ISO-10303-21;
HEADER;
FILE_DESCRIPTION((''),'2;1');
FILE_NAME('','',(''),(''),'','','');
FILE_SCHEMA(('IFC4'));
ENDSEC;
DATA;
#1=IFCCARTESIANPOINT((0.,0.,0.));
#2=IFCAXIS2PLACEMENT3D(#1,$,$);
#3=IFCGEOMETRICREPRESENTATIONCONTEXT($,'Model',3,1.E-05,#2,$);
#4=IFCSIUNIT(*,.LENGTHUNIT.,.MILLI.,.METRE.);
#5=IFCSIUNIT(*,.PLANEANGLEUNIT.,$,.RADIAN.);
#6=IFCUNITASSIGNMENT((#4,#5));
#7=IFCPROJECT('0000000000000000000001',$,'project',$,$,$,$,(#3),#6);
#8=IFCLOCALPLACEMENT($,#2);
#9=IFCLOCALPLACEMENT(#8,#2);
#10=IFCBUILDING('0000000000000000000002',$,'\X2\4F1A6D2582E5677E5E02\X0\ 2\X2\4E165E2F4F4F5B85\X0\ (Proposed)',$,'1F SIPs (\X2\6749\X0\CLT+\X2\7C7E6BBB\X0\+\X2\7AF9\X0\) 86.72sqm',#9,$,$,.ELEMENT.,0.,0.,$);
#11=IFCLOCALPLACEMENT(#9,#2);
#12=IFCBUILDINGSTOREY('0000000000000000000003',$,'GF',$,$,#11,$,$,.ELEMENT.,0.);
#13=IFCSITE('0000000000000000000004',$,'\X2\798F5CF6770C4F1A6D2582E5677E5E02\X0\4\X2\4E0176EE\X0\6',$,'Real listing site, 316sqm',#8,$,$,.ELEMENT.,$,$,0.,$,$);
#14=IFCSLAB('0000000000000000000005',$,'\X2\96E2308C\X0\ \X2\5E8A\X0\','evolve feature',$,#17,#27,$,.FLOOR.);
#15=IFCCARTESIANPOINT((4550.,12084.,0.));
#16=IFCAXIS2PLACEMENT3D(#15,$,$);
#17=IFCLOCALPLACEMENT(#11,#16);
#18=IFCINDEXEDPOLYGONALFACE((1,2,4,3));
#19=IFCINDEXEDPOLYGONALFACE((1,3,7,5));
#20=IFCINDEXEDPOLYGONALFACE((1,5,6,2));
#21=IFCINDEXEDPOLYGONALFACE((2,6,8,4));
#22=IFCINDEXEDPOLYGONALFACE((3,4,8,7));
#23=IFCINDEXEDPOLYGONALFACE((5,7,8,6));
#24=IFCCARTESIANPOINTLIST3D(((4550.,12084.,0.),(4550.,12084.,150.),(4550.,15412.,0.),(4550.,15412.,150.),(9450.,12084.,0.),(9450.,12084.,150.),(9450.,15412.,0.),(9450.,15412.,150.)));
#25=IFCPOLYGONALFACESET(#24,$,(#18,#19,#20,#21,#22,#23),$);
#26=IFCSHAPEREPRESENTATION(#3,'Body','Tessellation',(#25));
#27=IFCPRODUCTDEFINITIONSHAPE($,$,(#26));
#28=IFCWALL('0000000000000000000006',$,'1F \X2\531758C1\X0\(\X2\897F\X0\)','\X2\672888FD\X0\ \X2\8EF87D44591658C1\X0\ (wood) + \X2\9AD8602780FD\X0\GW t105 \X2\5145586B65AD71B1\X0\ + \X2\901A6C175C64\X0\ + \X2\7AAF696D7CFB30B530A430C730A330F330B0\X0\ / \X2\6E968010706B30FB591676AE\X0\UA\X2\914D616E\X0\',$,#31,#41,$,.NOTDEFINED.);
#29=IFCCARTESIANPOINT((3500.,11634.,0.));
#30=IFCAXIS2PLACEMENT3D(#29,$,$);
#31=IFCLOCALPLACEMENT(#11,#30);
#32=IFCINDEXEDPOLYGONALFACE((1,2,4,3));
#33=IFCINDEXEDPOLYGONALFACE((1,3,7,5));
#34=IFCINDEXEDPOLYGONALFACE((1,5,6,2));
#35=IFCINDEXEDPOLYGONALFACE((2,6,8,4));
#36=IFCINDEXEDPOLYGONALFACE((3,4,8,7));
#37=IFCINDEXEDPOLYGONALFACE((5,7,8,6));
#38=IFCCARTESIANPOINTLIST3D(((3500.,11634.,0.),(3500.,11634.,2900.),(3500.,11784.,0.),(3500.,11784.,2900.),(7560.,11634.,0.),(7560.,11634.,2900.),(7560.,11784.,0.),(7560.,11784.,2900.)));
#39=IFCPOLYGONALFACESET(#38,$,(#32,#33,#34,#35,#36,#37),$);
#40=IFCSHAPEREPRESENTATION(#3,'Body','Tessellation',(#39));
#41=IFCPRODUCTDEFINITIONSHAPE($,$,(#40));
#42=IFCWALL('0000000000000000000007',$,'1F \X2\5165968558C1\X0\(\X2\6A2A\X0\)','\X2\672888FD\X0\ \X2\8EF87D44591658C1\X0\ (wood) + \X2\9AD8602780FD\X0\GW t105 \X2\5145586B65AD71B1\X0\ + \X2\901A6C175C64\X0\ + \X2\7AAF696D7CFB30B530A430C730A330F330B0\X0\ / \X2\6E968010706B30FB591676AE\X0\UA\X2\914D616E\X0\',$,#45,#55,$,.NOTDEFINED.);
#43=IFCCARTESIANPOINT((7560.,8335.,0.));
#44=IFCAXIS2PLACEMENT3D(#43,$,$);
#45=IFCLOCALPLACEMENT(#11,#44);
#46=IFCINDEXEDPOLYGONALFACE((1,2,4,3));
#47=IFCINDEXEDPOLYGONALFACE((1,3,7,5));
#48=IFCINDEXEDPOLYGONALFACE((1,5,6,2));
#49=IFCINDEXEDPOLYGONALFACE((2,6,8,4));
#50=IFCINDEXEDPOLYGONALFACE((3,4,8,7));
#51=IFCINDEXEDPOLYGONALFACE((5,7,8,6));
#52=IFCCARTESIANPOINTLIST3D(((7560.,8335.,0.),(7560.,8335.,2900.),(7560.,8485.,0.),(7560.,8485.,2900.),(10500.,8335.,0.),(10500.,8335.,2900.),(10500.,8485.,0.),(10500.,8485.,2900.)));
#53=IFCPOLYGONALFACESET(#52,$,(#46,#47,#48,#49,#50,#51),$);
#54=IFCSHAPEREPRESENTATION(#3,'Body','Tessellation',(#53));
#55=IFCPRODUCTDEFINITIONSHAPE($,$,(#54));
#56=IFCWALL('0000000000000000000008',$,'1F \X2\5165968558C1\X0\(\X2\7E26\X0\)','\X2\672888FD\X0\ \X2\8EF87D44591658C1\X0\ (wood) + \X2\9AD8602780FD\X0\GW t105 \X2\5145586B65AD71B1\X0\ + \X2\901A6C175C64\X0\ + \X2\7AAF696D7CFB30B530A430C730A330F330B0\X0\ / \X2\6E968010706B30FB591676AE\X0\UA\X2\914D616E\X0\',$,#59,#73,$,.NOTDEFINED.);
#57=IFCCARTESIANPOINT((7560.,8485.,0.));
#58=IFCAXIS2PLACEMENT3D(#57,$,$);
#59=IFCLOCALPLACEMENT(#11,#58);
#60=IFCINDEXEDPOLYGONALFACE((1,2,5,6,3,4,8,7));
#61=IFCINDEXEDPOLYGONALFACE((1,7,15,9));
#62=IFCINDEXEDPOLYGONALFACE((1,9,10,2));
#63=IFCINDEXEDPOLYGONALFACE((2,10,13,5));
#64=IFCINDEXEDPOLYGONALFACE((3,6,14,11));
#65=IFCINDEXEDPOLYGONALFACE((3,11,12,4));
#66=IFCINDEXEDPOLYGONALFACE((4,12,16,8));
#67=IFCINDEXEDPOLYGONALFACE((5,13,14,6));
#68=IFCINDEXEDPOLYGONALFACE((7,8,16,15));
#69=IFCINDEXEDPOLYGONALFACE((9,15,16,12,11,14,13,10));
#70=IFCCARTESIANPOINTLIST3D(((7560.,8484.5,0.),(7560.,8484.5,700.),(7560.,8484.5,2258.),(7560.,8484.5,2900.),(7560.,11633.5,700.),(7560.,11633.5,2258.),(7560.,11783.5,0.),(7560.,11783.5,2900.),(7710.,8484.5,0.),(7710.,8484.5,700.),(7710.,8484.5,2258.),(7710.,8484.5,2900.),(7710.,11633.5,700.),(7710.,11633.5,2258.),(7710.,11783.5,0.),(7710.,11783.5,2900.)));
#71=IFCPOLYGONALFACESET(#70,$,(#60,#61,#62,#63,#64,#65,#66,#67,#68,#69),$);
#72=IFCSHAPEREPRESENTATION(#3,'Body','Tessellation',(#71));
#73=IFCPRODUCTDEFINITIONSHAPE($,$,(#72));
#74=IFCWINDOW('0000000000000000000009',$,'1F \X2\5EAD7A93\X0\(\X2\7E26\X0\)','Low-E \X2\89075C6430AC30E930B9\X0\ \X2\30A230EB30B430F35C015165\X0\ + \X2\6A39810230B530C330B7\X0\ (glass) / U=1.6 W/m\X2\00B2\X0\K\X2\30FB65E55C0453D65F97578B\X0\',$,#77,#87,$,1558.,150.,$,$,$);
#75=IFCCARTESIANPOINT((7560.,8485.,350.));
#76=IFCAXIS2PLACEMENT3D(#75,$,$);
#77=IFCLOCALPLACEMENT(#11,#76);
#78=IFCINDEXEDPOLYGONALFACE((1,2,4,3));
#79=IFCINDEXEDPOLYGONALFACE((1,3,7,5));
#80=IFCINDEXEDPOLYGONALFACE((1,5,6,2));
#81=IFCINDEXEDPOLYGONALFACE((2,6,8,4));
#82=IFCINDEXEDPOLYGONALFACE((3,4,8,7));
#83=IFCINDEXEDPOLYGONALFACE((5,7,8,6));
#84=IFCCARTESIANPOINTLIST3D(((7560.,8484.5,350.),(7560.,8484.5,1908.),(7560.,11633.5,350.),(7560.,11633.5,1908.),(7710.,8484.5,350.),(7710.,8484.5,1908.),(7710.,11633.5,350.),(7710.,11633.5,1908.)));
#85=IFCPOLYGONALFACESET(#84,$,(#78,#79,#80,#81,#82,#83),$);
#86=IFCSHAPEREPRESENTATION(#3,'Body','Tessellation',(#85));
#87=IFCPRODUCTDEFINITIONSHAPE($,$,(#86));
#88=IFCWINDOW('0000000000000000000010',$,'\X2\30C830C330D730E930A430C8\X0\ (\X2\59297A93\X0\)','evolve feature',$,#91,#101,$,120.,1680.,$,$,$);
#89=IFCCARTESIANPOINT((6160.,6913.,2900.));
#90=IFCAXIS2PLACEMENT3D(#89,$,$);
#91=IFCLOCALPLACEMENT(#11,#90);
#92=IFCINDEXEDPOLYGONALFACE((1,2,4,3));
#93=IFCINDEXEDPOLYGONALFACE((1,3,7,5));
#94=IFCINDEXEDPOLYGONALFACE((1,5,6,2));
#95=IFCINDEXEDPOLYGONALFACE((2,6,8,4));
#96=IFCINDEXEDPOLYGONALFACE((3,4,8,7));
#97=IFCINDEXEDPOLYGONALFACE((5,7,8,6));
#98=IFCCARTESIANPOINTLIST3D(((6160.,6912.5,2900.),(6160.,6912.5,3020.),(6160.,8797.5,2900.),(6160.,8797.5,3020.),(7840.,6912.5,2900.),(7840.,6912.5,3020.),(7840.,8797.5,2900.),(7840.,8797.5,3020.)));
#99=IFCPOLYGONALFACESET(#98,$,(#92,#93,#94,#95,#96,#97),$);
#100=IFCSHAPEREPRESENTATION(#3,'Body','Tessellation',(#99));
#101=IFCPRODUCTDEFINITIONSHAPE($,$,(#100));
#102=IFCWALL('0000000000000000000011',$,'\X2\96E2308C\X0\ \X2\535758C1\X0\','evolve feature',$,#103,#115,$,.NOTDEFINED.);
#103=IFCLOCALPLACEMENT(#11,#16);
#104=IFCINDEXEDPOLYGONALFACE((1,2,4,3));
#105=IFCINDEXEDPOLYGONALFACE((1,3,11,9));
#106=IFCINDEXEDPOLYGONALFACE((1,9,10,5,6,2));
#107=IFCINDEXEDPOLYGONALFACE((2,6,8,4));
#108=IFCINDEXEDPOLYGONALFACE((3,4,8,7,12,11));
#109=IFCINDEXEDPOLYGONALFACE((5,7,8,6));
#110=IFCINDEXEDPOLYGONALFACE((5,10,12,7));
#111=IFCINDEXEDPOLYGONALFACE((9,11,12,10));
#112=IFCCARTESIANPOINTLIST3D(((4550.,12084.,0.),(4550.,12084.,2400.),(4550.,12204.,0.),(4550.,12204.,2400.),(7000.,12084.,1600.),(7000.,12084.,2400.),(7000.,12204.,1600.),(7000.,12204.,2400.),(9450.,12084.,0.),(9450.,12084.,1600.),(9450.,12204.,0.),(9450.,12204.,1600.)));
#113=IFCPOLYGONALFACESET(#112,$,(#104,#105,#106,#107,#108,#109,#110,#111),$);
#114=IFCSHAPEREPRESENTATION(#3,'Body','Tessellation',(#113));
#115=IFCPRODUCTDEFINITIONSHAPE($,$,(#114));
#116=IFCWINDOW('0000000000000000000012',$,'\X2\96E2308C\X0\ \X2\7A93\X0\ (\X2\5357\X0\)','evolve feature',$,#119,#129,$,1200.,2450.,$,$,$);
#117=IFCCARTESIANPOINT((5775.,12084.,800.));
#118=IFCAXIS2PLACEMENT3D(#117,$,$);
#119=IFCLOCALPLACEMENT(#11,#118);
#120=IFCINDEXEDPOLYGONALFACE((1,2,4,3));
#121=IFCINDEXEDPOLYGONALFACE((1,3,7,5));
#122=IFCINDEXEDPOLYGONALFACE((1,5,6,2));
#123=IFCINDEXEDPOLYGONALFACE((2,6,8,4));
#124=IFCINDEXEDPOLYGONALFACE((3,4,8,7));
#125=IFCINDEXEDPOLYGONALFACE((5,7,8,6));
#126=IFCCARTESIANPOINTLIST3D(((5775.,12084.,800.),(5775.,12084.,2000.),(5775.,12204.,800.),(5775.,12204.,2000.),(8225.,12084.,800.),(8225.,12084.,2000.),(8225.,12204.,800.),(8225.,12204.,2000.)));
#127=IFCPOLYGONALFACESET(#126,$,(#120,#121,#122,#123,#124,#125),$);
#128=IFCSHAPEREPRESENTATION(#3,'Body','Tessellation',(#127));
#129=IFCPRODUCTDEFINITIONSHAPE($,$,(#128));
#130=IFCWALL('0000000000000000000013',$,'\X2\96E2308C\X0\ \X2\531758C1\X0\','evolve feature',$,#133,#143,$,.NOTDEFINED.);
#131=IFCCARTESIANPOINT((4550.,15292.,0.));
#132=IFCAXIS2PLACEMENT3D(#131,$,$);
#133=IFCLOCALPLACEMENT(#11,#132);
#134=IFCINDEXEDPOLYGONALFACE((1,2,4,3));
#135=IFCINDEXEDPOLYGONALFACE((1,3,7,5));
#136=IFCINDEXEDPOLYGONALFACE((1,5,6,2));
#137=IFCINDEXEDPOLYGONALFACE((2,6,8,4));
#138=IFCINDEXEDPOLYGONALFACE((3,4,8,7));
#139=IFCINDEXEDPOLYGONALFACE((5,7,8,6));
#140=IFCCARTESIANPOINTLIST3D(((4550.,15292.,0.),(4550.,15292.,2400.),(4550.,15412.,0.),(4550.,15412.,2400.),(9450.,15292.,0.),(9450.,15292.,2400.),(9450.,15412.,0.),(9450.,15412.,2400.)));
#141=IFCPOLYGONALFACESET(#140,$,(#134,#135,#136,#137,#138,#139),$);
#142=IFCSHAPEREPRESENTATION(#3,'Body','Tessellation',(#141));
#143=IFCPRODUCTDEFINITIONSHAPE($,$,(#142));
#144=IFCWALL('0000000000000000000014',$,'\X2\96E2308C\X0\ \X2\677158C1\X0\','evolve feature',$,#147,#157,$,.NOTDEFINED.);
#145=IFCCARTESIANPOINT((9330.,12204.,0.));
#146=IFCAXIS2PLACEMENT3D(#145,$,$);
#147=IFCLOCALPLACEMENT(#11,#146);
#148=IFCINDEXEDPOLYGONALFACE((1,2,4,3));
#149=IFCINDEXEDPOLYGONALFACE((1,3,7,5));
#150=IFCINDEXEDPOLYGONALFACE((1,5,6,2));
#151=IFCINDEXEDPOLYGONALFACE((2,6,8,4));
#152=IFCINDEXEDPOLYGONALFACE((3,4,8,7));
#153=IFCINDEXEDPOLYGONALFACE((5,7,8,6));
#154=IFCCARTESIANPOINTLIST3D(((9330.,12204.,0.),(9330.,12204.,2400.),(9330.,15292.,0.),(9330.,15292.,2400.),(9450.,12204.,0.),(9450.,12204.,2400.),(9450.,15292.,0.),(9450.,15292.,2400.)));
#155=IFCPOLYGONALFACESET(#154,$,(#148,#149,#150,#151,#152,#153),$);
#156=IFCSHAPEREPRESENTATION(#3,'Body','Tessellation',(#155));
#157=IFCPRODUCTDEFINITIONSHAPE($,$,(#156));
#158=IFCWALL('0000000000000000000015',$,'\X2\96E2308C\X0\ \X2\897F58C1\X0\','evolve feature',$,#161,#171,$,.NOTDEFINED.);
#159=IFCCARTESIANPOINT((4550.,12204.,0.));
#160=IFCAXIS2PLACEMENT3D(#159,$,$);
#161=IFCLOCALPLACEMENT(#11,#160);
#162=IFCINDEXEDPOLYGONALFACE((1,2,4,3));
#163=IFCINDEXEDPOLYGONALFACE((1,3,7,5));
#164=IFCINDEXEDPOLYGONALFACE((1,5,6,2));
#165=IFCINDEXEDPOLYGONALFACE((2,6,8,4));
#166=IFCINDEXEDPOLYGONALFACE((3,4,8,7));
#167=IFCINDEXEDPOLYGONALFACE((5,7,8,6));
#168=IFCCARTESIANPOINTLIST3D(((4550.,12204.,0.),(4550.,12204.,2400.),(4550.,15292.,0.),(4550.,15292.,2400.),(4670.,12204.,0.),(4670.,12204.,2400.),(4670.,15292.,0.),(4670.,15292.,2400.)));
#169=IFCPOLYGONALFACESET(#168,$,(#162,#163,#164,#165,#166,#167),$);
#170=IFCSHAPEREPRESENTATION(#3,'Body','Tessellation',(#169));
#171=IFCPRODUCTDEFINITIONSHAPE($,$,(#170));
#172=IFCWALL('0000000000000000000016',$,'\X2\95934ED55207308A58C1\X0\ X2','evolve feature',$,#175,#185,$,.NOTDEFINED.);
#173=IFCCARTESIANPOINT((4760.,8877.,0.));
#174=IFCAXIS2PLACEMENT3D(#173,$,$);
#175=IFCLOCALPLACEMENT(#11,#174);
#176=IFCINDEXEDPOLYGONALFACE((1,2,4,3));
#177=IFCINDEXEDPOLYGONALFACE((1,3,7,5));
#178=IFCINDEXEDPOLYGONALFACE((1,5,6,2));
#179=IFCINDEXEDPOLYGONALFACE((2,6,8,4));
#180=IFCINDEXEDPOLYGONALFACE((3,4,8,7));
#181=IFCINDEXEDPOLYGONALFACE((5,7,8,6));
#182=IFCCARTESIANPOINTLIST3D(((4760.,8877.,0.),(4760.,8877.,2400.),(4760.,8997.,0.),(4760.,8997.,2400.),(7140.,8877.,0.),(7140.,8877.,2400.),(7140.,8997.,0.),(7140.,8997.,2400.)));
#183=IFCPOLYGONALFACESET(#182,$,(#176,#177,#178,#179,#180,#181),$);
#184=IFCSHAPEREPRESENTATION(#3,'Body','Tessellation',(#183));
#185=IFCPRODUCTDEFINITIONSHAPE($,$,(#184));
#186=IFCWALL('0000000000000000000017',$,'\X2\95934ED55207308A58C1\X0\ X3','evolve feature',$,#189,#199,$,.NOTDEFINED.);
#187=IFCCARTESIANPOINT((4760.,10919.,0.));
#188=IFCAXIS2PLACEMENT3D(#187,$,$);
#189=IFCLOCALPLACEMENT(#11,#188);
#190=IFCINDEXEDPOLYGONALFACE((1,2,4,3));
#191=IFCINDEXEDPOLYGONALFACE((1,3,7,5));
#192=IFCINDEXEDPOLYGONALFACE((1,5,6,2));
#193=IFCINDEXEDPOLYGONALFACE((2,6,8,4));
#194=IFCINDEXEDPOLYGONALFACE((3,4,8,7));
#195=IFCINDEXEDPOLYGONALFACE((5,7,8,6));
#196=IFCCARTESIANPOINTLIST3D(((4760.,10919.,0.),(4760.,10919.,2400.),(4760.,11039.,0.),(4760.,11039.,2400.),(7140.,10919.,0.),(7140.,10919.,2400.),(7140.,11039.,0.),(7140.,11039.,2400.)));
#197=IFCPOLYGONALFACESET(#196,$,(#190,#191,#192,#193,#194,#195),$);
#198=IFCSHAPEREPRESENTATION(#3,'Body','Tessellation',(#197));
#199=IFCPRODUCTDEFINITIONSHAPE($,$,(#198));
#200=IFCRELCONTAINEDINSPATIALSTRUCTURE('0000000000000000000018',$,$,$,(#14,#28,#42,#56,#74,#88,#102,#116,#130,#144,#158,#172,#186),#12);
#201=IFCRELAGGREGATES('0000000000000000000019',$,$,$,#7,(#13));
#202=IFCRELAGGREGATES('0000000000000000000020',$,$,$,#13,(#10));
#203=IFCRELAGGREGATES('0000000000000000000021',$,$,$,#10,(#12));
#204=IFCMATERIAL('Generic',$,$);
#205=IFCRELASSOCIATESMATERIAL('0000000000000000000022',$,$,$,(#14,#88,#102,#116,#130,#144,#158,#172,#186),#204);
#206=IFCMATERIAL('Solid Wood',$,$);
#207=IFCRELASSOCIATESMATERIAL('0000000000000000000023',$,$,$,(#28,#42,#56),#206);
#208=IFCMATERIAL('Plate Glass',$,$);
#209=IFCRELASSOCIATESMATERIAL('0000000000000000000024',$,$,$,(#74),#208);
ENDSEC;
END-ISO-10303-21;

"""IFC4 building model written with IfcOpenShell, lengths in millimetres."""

from ifc_helpers import new_model, si_unit, frame, frame_2d, origin, place, context, project, spatial, rectangle, extrude, material, element, fill, save


model = new_model("IFC4")

# Units and contexts
model_context = context("Model", 3, precision=1e-05, world=origin())
ifc_project = project(units=[si_unit("LENGTHUNIT", "METRE", prefix="MILLI"), si_unit("PLANEANGLEUNIT", "RADIAN")], contexts=[model_context])

# Site, building, storey
site_placement = place(None, origin())
site = spatial("IfcSite", under=ifc_project, at=site_placement, Name="福島県会津若松市4丁目6", ObjectType="Real listing site, 316sqm", CompositionType="ELEMENT", RefElevation=0.0)
building_placement = place(site_placement, origin())
building = spatial("IfcBuilding", under=site, at=building_placement, Name="会津若松市 2世帯住宅 (Proposed)", ObjectType="1F SIPs (杉CLT+籾殻+竹) 86.72sqm", CompositionType="ELEMENT", ElevationOfRefHeight=0.0, ElevationOfTerrain=0.0)
storey_placement = place(building_placement, origin())
storey = spatial("IfcBuildingStorey", under=building, at=storey_placement, Name="GF", CompositionType="ELEMENT", Elevation=0.0)

# Slab
ifc_material_1 = material(Name="Solid Wood")
ifc_material_2 = material(Name="Generic")
slab_1_placement = place(storey_placement, frame((4550.0, 12084.0, 0.0)))
element("IfcSlab", 1, at=slab_1_placement, inside=storey, material=ifc_material_2, Name="離れ 床", Description="evolve feature", PredefinedType="FLOOR", context=model_context, shape_type="SweptSolid", body=[
    extrude(rectangle(XDim=4900.0, YDim=3328.0, at=frame_2d((2450.0, 1664.0))), frame((4550.0, 12084.0, 0.0)), (0.0, 0.0, 1.0), 150.0),
])

# Walls
wall_1_placement = place(storey_placement, frame((3500.0, 11634.0, 0.0)))
element("IfcWall", 2, at=wall_1_placement, inside=storey, material=ifc_material_1, Name="1F 北壁(西)", Description="木製 軸組外壁 (wood) + 高性能GW t105 充填断熱 + 通気層 + 窯業系サイディング / 準耐火・外皮UA配慮", PredefinedType="NOTDEFINED", context=model_context, shape_type="SweptSolid", body=[
    extrude(rectangle(XDim=4060.0, YDim=150.0, at=frame_2d((2030.0, 75.0))), frame((3500.0, 11634.0, 0.0)), (0.0, 0.0, 1.0), 2900.0),
])
wall_2_placement = place(storey_placement, frame((7560.0, 8335.0, 0.0)))
element("IfcWall", 3, at=wall_2_placement, inside=storey, material=ifc_material_1, Name="1F 入隅壁(横)", Description="木製 軸組外壁 (wood) + 高性能GW t105 充填断熱 + 通気層 + 窯業系サイディング / 準耐火・外皮UA配慮", PredefinedType="NOTDEFINED", context=model_context, shape_type="SweptSolid", body=[
    extrude(rectangle(XDim=2940.0, YDim=150.0, at=frame_2d((1470.0, 75.0))), frame((7560.0, 8335.0, 0.0)), (0.0, 0.0, 1.0), 2900.0),
])

# Wall, opening, window
wall_3_placement = place(storey_placement, frame((7560.0, 8485.0, 0.0)))
wall_3 = element("IfcWall", 4, at=wall_3_placement, inside=storey, material=ifc_material_1, Name="1F 入隅壁(縦)", Description="木製 軸組外壁 (wood) + 高性能GW t105 充填断熱 + 通気層 + 窯業系サイディング / 準耐火・外皮UA配慮", PredefinedType="NOTDEFINED", context=model_context, shape_type="SweptSolid", body=[
    extrude(rectangle(XDim=150.0, YDim=3299.0, at=frame_2d((75.0, 1649.0))), frame((7560.0, 8485.0, 0.0)), (0.0, 0.0, 1.0), 2900.0),
])
opening_1_placement = place(storey_placement, frame((7560.0, 8485.0, 350.0)))
opening_1 = element("IfcOpeningElement", 5, at=opening_1_placement, cuts=wall_3, PredefinedType="NOTDEFINED", context=model_context, shape_type="SweptSolid", body=[
    extrude(rectangle(XDim=150.0, YDim=3149.0, at=frame_2d((75.0, 1574.0))), frame((7560.0, 8485.0, 350.0)), (0.0, 0.0, 1.0), 1558.0),
])
ifc_material_3 = material(Name="Plate Glass")
window_1_placement = place(storey_placement, frame((7560.0, 8485.0, 350.0)))
window_1 = element("IfcWindow", 6, at=window_1_placement, inside=storey, material=ifc_material_3, Name="1F 庭窓(縦)", Description="Low-E 複層ガラス アルゴン封入 + 樹脂サッシ (glass) / U=1.6 W/m²K・日射取得型", OverallHeight=1558.0, OverallWidth=150.0, context=model_context, shape_type="SweptSolid", body=[
    extrude(rectangle(XDim=150.0, YDim=3149.0, at=frame_2d((75.0, 1574.0))), frame((7560.0, 8485.0, 350.0)), (0.0, 0.0, 1.0), 1558.0),
])
fill(opening_1, window_1)

# Window
window_2_placement = place(storey_placement, frame((6160.0, 6913.0, 2900.0)))
element("IfcWindow", 7, at=window_2_placement, inside=storey, material=ifc_material_2, Name="トップライト (天窓)", Description="evolve feature", OverallHeight=120.0, OverallWidth=1680.0, context=model_context, shape_type="SweptSolid", body=[
    extrude(rectangle(XDim=1680.0, YDim=1885.0, at=frame_2d((840.0, 942.0))), frame((6160.0, 6913.0, 2900.0)), (0.0, 0.0, 1.0), 120.0),
])

# Wall, opening, window
wall_4_placement = place(storey_placement, frame((4550.0, 12084.0, 0.0)))
wall_4 = element("IfcWall", 8, at=wall_4_placement, inside=storey, material=ifc_material_2, Name="離れ 南壁", Description="evolve feature", PredefinedType="NOTDEFINED", context=model_context, shape_type="SweptSolid", body=[
    extrude(rectangle(XDim=4900.0, YDim=120.0, at=frame_2d((2450.0, 60.0))), frame((4550.0, 12084.0, 0.0)), (0.0, 0.0, 1.0), 2400.0),
])
opening_2_placement = place(storey_placement, frame((5775.0, 12084.0, 800.0)))
opening_2 = element("IfcOpeningElement", 9, at=opening_2_placement, cuts=wall_4, PredefinedType="NOTDEFINED", context=model_context, shape_type="SweptSolid", body=[
    extrude(rectangle(XDim=2450.0, YDim=120.0, at=frame_2d((1225.0, 60.0))), frame((5775.0, 12084.0, 800.0)), (0.0, 0.0, 1.0), 1200.0),
])
window_3_placement = place(storey_placement, frame((5775.0, 12084.0, 800.0)))
window_3 = element("IfcWindow", 10, at=window_3_placement, inside=storey, material=ifc_material_2, Name="離れ 窓 (南)", Description="evolve feature", OverallHeight=1200.0, OverallWidth=2450.0, context=model_context, shape_type="SweptSolid", body=[
    extrude(rectangle(XDim=2450.0, YDim=120.0, at=frame_2d((1225.0, 60.0))), frame((5775.0, 12084.0, 800.0)), (0.0, 0.0, 1.0), 1200.0),
])
fill(opening_2, window_3)

# Walls
wall_5_placement = place(storey_placement, frame((4550.0, 15292.0, 0.0)))
element("IfcWall", 11, at=wall_5_placement, inside=storey, material=ifc_material_2, Name="離れ 北壁", Description="evolve feature", PredefinedType="NOTDEFINED", context=model_context, shape_type="SweptSolid", body=[
    extrude(rectangle(XDim=4900.0, YDim=120.0, at=frame_2d((2450.0, 60.0))), frame((4550.0, 15292.0, 0.0)), (0.0, 0.0, 1.0), 2400.0),
])
wall_6_placement = place(storey_placement, frame((9330.0, 12204.0, 0.0)))
element("IfcWall", 12, at=wall_6_placement, inside=storey, material=ifc_material_2, Name="離れ 東壁", Description="evolve feature", PredefinedType="NOTDEFINED", context=model_context, shape_type="SweptSolid", body=[
    extrude(rectangle(XDim=120.0, YDim=3088.0, at=frame_2d((60.0, 1544.0))), frame((9330.0, 12204.0, 0.0)), (0.0, 0.0, 1.0), 2400.0),
])
wall_7_placement = place(storey_placement, frame((4550.0, 12204.0, 0.0)))
element("IfcWall", 13, at=wall_7_placement, inside=storey, material=ifc_material_2, Name="離れ 西壁", Description="evolve feature", PredefinedType="NOTDEFINED", context=model_context, shape_type="SweptSolid", body=[
    extrude(rectangle(XDim=120.0, YDim=3088.0, at=frame_2d((60.0, 1544.0))), frame((4550.0, 12204.0, 0.0)), (0.0, 0.0, 1.0), 2400.0),
])
wall_8_placement = place(storey_placement, frame((4760.0, 8877.0, 0.0)))
element("IfcWall", 14, at=wall_8_placement, inside=storey, material=ifc_material_2, Name="間仕切り壁 X2", Description="evolve feature", PredefinedType="NOTDEFINED", context=model_context, shape_type="SweptSolid", body=[
    extrude(rectangle(XDim=2380.0, YDim=120.0, at=frame_2d((1190.0, 60.0))), frame((4760.0, 8877.0, 0.0)), (0.0, 0.0, 1.0), 2400.0),
])
wall_9_placement = place(storey_placement, frame((4760.0, 10919.0, 0.0)))
element("IfcWall", 15, at=wall_9_placement, inside=storey, material=ifc_material_2, Name="間仕切り壁 X3", Description="evolve feature", PredefinedType="NOTDEFINED", context=model_context, shape_type="SweptSolid", body=[
    extrude(rectangle(XDim=2380.0, YDim=120.0, at=frame_2d((1190.0, 60.0))), frame((4760.0, 10919.0, 0.0)), (0.0, 0.0, 1.0), 2400.0),
])

save(model, "model.ifc")
